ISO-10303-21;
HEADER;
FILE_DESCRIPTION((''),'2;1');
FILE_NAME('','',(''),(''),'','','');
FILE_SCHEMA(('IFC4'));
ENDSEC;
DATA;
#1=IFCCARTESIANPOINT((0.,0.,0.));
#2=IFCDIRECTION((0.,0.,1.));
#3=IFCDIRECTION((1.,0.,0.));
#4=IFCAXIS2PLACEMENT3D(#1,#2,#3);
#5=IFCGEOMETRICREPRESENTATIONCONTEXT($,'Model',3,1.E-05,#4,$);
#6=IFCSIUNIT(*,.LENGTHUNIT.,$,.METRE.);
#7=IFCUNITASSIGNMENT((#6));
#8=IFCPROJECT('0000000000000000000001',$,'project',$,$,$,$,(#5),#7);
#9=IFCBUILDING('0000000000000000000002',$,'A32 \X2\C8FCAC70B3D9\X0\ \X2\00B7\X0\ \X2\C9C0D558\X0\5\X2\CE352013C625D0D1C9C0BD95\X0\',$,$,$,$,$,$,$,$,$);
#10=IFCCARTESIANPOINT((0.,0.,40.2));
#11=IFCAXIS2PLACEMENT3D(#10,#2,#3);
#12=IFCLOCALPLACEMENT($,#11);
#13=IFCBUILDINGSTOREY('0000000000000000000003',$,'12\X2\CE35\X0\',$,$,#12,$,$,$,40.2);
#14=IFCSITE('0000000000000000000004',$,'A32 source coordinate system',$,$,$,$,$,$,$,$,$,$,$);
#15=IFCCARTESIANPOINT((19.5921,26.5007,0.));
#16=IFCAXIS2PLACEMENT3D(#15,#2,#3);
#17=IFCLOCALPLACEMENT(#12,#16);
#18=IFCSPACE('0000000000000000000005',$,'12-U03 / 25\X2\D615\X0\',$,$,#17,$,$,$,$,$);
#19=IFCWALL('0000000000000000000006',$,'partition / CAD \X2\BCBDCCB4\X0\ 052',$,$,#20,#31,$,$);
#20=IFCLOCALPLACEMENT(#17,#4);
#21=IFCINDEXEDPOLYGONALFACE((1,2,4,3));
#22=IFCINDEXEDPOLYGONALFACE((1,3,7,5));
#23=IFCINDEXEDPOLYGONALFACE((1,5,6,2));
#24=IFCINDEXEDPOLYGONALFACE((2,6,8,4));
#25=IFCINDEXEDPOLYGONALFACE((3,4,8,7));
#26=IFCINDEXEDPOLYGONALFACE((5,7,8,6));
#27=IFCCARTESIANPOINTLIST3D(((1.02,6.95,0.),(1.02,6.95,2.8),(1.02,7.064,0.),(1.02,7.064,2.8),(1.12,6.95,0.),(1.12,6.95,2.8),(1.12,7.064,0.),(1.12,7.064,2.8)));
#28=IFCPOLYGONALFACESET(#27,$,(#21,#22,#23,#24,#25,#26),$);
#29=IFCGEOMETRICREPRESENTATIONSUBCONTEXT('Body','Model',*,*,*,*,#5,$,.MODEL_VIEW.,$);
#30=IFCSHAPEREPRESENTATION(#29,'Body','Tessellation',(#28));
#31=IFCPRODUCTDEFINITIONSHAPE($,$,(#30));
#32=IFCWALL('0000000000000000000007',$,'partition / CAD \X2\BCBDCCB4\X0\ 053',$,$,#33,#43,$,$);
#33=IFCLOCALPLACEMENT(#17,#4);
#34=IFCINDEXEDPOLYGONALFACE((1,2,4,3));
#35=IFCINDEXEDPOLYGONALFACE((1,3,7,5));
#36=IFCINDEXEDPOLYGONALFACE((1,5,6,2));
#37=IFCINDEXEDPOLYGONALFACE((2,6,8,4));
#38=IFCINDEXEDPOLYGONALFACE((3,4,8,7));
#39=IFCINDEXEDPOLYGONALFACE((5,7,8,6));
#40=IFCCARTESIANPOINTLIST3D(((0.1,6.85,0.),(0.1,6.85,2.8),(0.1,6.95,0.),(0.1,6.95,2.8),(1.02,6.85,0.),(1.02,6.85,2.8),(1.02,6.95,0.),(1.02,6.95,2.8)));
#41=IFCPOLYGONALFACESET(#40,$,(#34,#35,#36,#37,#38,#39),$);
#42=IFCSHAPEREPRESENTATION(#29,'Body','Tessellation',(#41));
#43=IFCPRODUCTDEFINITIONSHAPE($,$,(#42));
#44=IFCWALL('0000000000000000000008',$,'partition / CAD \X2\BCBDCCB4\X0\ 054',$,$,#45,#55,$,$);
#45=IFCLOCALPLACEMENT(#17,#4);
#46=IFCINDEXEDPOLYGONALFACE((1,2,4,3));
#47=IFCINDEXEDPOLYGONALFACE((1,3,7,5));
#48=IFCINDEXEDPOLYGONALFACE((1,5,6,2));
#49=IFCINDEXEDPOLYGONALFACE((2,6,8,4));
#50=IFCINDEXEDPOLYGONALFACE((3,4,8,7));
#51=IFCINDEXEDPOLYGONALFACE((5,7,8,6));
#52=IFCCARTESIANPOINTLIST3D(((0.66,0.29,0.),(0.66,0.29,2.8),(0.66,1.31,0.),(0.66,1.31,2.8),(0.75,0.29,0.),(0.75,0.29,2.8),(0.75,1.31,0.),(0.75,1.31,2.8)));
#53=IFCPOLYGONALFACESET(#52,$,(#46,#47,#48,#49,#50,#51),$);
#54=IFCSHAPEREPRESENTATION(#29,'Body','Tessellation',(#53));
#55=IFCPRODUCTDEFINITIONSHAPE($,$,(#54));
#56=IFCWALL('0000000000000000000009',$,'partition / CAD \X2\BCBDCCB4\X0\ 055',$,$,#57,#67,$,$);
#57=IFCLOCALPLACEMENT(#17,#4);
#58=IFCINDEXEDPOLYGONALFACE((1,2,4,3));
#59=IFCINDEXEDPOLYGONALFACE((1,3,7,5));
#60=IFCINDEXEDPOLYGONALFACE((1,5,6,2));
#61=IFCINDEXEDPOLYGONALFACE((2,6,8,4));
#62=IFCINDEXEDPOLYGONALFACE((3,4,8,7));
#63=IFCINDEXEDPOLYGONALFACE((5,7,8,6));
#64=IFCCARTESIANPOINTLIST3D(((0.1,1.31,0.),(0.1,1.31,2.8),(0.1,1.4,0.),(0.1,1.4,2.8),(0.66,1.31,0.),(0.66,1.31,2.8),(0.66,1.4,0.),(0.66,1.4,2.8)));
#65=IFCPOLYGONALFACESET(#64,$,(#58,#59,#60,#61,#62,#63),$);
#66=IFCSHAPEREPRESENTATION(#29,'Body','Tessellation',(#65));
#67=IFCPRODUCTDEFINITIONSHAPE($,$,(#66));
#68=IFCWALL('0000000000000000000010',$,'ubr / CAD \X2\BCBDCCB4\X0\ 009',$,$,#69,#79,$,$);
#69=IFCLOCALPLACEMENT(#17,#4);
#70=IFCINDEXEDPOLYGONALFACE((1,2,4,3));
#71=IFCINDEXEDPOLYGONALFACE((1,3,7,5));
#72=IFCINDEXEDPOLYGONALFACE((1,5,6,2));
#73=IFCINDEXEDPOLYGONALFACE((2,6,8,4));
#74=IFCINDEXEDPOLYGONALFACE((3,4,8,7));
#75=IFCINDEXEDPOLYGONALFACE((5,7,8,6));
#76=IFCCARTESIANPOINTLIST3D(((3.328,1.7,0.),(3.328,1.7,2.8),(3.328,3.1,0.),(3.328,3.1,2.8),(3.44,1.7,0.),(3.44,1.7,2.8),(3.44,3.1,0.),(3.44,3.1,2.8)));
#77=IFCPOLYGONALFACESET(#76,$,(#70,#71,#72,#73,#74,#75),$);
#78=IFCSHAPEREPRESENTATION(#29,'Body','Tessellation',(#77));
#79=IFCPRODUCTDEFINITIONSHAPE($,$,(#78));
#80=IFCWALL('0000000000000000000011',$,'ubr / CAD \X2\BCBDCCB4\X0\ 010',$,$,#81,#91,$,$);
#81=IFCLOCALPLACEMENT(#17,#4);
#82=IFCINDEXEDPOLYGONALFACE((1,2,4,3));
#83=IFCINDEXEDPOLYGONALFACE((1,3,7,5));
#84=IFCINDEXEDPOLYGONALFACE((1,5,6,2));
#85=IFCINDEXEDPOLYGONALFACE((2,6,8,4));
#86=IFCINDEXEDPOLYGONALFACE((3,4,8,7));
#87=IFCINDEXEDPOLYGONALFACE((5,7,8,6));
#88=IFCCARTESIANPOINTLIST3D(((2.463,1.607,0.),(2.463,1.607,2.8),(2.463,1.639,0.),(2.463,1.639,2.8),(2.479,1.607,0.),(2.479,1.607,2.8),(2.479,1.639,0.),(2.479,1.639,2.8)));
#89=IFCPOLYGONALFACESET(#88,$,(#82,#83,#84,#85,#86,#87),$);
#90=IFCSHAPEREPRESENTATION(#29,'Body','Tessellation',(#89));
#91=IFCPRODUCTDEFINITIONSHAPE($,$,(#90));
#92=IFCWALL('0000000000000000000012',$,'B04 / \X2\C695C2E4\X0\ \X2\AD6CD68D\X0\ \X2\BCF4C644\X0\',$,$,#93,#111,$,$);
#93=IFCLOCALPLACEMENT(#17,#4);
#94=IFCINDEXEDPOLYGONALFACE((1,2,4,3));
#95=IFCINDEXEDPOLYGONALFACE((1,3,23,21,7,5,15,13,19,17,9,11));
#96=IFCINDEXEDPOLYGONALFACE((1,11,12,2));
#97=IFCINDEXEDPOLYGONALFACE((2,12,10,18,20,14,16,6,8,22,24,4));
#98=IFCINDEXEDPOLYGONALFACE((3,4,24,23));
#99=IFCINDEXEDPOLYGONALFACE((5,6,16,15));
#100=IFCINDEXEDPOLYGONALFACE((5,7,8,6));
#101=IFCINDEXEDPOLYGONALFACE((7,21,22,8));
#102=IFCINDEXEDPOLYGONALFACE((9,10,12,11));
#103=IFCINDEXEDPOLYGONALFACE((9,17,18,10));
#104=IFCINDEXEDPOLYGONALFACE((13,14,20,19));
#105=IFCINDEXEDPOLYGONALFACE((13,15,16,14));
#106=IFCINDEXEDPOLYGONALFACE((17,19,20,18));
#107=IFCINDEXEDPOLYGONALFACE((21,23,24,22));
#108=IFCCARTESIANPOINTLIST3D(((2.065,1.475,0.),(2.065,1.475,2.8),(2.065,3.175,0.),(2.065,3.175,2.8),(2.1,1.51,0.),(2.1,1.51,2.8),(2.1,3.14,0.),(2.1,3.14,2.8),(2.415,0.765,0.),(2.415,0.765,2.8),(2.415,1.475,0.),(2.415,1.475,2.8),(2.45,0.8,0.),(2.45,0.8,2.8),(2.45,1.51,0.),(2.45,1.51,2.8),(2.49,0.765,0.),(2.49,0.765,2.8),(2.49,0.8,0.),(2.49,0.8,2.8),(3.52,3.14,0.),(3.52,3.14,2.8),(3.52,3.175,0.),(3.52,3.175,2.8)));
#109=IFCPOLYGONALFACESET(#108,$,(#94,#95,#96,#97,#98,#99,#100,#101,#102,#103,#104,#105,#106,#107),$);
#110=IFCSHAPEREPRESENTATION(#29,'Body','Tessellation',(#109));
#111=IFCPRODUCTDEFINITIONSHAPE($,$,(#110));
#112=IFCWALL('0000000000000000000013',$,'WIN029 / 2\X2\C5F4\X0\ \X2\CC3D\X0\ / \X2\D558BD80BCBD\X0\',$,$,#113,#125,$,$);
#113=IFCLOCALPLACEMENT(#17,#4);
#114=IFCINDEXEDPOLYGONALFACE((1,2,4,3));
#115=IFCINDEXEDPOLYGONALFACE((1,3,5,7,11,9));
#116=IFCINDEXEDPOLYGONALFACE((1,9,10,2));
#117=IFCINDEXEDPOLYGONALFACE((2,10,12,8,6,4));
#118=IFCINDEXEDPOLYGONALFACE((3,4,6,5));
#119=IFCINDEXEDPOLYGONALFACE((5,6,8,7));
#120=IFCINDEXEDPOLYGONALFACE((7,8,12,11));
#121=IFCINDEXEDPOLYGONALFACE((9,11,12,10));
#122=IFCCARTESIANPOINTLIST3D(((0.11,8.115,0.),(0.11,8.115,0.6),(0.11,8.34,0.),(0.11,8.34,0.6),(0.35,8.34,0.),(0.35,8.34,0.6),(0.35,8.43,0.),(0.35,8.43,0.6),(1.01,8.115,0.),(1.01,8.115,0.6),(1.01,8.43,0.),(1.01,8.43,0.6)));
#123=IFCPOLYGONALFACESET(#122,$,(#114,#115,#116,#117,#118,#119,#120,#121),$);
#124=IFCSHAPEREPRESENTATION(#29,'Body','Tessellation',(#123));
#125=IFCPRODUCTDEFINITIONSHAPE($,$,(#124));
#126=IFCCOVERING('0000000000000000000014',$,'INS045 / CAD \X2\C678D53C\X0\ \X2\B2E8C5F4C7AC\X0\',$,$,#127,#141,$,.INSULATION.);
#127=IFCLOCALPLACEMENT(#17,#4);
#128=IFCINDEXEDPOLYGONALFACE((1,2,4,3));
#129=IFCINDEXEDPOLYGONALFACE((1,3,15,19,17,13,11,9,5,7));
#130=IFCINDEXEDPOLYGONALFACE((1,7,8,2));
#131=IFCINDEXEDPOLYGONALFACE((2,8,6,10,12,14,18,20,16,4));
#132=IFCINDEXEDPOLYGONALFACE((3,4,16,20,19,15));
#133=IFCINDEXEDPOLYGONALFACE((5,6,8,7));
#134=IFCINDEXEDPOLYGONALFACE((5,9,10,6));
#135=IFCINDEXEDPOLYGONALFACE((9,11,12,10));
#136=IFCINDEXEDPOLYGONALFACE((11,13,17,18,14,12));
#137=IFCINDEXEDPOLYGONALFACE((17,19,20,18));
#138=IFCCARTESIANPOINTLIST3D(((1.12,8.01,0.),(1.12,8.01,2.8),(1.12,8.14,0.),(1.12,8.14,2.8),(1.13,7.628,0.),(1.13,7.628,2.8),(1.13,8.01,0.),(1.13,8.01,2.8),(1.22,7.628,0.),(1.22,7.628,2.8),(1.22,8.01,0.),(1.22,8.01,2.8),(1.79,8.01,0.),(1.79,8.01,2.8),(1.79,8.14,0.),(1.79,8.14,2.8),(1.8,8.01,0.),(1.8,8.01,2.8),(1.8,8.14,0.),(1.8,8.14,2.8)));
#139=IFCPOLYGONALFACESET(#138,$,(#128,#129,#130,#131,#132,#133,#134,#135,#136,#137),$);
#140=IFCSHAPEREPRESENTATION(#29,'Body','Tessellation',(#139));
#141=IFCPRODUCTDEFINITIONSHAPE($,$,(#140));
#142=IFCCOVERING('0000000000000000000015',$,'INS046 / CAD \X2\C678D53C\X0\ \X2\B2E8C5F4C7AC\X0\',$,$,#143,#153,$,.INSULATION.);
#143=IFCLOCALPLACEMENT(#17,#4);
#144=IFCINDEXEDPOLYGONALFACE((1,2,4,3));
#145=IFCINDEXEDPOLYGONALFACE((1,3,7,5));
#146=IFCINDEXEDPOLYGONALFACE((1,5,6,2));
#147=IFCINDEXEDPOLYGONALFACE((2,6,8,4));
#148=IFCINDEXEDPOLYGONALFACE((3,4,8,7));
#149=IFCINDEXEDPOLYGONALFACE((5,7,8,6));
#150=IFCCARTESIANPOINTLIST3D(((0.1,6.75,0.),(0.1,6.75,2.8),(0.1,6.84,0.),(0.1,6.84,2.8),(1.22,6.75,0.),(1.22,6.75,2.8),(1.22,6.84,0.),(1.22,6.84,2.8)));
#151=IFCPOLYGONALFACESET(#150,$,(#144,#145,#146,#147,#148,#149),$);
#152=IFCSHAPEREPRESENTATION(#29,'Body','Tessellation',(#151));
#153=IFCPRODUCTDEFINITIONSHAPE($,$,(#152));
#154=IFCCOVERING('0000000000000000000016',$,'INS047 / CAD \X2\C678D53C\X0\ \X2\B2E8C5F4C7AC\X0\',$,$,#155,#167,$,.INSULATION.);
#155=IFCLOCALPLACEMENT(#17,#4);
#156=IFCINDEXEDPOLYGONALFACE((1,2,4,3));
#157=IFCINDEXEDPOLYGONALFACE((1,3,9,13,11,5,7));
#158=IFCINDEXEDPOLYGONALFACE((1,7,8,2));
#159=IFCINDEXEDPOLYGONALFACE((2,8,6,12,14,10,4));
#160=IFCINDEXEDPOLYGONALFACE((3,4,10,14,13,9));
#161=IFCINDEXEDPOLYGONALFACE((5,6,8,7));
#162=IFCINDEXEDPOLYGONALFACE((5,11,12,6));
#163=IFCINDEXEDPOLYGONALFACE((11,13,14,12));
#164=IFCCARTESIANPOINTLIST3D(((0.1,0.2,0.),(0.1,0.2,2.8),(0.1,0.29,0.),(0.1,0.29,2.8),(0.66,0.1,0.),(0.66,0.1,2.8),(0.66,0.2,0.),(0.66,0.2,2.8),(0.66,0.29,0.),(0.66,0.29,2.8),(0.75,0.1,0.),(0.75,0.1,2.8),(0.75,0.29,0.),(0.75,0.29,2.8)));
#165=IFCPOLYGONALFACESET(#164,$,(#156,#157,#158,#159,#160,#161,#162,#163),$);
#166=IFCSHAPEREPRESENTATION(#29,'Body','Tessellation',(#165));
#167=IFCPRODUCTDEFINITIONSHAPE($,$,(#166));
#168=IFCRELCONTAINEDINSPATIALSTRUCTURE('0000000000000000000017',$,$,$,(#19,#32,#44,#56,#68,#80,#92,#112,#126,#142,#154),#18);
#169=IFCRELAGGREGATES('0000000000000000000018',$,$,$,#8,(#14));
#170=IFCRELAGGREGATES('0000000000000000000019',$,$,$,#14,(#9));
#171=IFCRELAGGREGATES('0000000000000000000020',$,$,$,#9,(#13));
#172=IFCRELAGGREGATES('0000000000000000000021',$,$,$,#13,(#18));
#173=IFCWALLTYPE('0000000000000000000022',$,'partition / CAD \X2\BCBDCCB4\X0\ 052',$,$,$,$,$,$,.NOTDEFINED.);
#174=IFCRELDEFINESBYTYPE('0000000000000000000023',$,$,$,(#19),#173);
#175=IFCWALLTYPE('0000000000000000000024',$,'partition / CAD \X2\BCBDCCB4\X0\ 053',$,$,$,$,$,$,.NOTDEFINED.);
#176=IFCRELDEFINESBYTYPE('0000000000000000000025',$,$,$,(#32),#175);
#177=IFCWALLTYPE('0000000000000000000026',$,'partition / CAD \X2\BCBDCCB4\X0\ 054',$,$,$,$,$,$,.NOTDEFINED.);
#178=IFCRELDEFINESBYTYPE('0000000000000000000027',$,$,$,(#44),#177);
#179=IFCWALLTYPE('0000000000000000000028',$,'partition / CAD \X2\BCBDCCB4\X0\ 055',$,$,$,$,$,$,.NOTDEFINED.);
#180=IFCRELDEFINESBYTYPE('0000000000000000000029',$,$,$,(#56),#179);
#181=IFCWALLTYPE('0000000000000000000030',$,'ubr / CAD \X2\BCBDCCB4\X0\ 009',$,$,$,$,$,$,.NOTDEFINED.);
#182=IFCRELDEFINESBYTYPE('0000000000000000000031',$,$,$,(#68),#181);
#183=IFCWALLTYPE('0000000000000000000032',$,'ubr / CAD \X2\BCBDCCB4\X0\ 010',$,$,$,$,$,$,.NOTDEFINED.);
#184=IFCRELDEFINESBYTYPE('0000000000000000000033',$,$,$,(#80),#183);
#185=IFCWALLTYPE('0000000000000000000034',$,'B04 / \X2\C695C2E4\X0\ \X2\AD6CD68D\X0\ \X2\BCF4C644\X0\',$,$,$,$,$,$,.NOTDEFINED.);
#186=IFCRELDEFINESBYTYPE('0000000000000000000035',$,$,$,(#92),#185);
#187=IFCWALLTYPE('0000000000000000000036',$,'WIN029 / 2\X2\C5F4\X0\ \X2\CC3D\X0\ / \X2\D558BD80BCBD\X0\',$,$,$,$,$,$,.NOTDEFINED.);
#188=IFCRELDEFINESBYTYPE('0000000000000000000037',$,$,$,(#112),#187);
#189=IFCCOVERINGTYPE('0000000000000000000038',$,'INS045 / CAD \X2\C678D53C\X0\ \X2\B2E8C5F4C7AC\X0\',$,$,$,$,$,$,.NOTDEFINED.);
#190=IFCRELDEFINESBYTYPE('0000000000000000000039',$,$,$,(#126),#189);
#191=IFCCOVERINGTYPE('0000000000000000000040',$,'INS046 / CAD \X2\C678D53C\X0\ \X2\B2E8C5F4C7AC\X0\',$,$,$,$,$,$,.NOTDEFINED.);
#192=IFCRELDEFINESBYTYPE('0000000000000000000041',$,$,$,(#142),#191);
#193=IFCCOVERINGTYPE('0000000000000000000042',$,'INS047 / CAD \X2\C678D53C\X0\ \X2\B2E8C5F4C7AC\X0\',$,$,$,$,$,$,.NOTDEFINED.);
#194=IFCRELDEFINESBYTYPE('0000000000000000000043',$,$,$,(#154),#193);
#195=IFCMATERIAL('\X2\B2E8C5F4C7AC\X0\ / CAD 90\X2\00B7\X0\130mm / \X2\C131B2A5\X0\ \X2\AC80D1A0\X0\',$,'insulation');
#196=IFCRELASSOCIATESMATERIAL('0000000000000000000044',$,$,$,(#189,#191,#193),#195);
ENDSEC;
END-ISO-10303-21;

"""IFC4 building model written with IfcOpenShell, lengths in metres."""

from ifc_helpers import new_model, si_unit, frame, origin, origin_with_axes, place, context, subcontext, project, spatial, polyline, outline, extrude, source, transform, mapped, material, type_object, type_shapes, element, save


model = new_model("IFC4")

# Units and contexts
model_context = context("Model", 3, precision=1e-05, world=origin_with_axes())
body_context = subcontext(model_context, "Body", "Model", "MODEL_VIEW")
ifc_project = project(units=[si_unit("LENGTHUNIT", "METRE")], contexts=[model_context])

# Site, building, storey, space
storey_placement = place(None, frame((0.0, 0.0, 40.2), z_axis=(0.0, 0.0, 1.0), x_axis=(1.0, 0.0, 0.0)))
space_placement = place(storey_placement, frame((19.5921, 26.5007, 0.0), z_axis=(0.0, 0.0, 1.0), x_axis=(1.0, 0.0, 0.0)))
site = spatial("IfcSite", under=ifc_project, Name="A32 source coordinate system")
building = spatial("IfcBuilding", under=site, Name="A32 주거동 · 지하5층–옥탑지붕")
storey = spatial("IfcBuildingStorey", under=building, at=storey_placement, Name="12층", Elevation=40.2)
space = spatial("IfcSpace", under=storey, at=space_placement, Name="12-U03 / 25형")

# Walls
wall_type_1 = type_object("IfcWallType", Name="partition / CAD 벽체 052", PredefinedType="NOTDEFINED")
shared_shape_1 = source(origin(), body_context, "Body", "SweptSolid", [
    extrude(outline(polyline([(1.12, 6.95), (1.02, 6.95), (1.02, 7.064), (1.12, 7.064), (1.12, 6.95)])), origin(), (0.0, 0.0, 1.0), 2.8),
])
type_shapes(wall_type_1, [shared_shape_1])
wall_1_placement = place(space_placement, origin_with_axes())
element("IfcWall", 1, at=wall_1_placement, inside=space, type_object=wall_type_1, Name="partition / CAD 벽체 052", context=body_context, shape_type="MappedRepresentation", body=[
    mapped(shared_shape_1, transform((0.0, 0.0, 0.0), scale=1.0)),
])
wall_type_2 = type_object("IfcWallType", Name="partition / CAD 벽체 053", PredefinedType="NOTDEFINED")
shared_shape_2 = source(origin(), body_context, "Body", "SweptSolid", [
    extrude(outline(polyline([(1.02, 6.95), (1.02, 6.85), (0.1, 6.85), (0.1, 6.95), (1.02, 6.95)])), origin(), (0.0, 0.0, 1.0), 2.8),
])
type_shapes(wall_type_2, [shared_shape_2])
wall_2_placement = place(space_placement, origin_with_axes())
element("IfcWall", 2, at=wall_2_placement, inside=space, type_object=wall_type_2, Name="partition / CAD 벽체 053", context=body_context, shape_type="MappedRepresentation", body=[
    mapped(shared_shape_2, transform((0.0, 0.0, 0.0), scale=1.0)),
])
wall_type_3 = type_object("IfcWallType", Name="partition / CAD 벽체 054", PredefinedType="NOTDEFINED")
shared_shape_3 = source(origin(), body_context, "Body", "SweptSolid", [
    extrude(outline(polyline([(0.75, 0.29), (0.66, 0.29), (0.66, 1.31), (0.75, 1.31), (0.75, 0.29)])), origin(), (0.0, 0.0, 1.0), 2.8),
])
type_shapes(wall_type_3, [shared_shape_3])
wall_3_placement = place(space_placement, origin_with_axes())
element("IfcWall", 3, at=wall_3_placement, inside=space, type_object=wall_type_3, Name="partition / CAD 벽체 054", context=body_context, shape_type="MappedRepresentation", body=[
    mapped(shared_shape_3, transform((0.0, 0.0, 0.0), scale=1.0)),
])
wall_type_4 = type_object("IfcWallType", Name="partition / CAD 벽체 055", PredefinedType="NOTDEFINED")
shared_shape_4 = source(origin(), body_context, "Body", "SweptSolid", [
    extrude(outline(polyline([(0.66, 1.4), (0.66, 1.31), (0.1, 1.31), (0.1, 1.4), (0.66, 1.4)])), origin(), (0.0, 0.0, 1.0), 2.8),
])
type_shapes(wall_type_4, [shared_shape_4])
wall_4_placement = place(space_placement, origin_with_axes())
element("IfcWall", 4, at=wall_4_placement, inside=space, type_object=wall_type_4, Name="partition / CAD 벽체 055", context=body_context, shape_type="MappedRepresentation", body=[
    mapped(shared_shape_4, transform((0.0, 0.0, 0.0), scale=1.0)),
])
wall_type_5 = type_object("IfcWallType", Name="ubr / CAD 벽체 009", PredefinedType="NOTDEFINED")
shared_shape_5 = source(origin(), body_context, "Body", "SweptSolid", [
    extrude(outline(polyline([(3.328, 3.1), (3.44, 3.1), (3.44, 1.7), (3.328, 1.7), (3.328, 3.1)])), origin(), (0.0, 0.0, 1.0), 2.8),
])
type_shapes(wall_type_5, [shared_shape_5])
wall_5_placement = place(space_placement, origin_with_axes())
element("IfcWall", 5, at=wall_5_placement, inside=space, type_object=wall_type_5, Name="ubr / CAD 벽체 009", context=body_context, shape_type="MappedRepresentation", body=[
    mapped(shared_shape_5, transform((0.0, 0.0, 0.0), scale=1.0)),
])
wall_type_6 = type_object("IfcWallType", Name="ubr / CAD 벽체 010", PredefinedType="NOTDEFINED")
shared_shape_6 = source(origin(), body_context, "Body", "SweptSolid", [
    extrude(outline(polyline([(2.463, 1.607), (2.463, 1.639), (2.479, 1.639), (2.479, 1.607), (2.463, 1.607)])), origin(), (0.0, 0.0, 1.0), 2.8),
])
type_shapes(wall_type_6, [shared_shape_6])
wall_6_placement = place(space_placement, origin_with_axes())
element("IfcWall", 6, at=wall_6_placement, inside=space, type_object=wall_type_6, Name="ubr / CAD 벽체 010", context=body_context, shape_type="MappedRepresentation", body=[
    mapped(shared_shape_6, transform((0.0, 0.0, 0.0), scale=1.0)),
])
wall_type_7 = type_object("IfcWallType", Name="B04 / 욕실 구획 보완", PredefinedType="NOTDEFINED")
shared_shape_7 = source(origin(), body_context, "Body", "SweptSolid", [
    extrude(outline(polyline([(3.52, 3.175), (3.52, 3.14), (2.1, 3.14), (2.1, 1.51), (2.45, 1.51), (2.45, 0.8), (2.49, 0.8), (2.49, 0.765), (2.415, 0.765), (2.415, 1.475), (2.065, 1.475), (2.065, 3.175), (3.52, 3.175)])), origin(), (0.0, 0.0, 1.0), 2.8),
])
type_shapes(wall_type_7, [shared_shape_7])
wall_7_placement = place(space_placement, origin_with_axes())
element("IfcWall", 7, at=wall_7_placement, inside=space, type_object=wall_type_7, Name="B04 / 욕실 구획 보완", context=body_context, shape_type="MappedRepresentation", body=[
    mapped(shared_shape_7, transform((0.0, 0.0, 0.0), scale=1.0)),
])
wall_type_8 = type_object("IfcWallType", Name="WIN029 / 2열 창 / 하부벽", PredefinedType="NOTDEFINED")
shared_shape_8 = source(origin(), body_context, "Body", "SweptSolid", [
    extrude(outline(polyline([(1.01, 8.115), (0.11, 8.115), (0.11, 8.34), (0.35, 8.34), (0.35, 8.43), (1.01, 8.43), (1.01, 8.115)])), origin(), (0.0, 0.0, 1.0), 0.6),
])
type_shapes(wall_type_8, [shared_shape_8])
wall_8_placement = place(space_placement, origin_with_axes())
element("IfcWall", 8, at=wall_8_placement, inside=space, type_object=wall_type_8, Name="WIN029 / 2열 창 / 하부벽", context=body_context, shape_type="MappedRepresentation", body=[
    mapped(shared_shape_8, transform((0.0, 0.0, 0.0), scale=1.0)),
])

# Coverings
ifc_material = material(Name="단열재 / CAD 90·130mm / 성능 검토", Category="insulation")
covering_type_1 = type_object("IfcCoveringType", Name="INS045 / CAD 외피 단열재", PredefinedType="NOTDEFINED", material=ifc_material)
shared_shape_9 = source(origin(), body_context, "Body", "SweptSolid", [
    extrude(outline(polyline([(1.22, 8.01), (1.22, 7.628), (1.13, 7.628), (1.13, 8.01), (1.12, 8.01), (1.12, 8.14), (1.79, 8.14), (1.8, 8.14), (1.8, 8.01), (1.79, 8.01), (1.22, 8.01)])), origin(), (0.0, 0.0, 1.0), 2.8),
])
type_shapes(covering_type_1, [shared_shape_9])
covering_1_placement = place(space_placement, origin_with_axes())
element("IfcCovering", 9, at=covering_1_placement, inside=space, type_object=covering_type_1, Name="INS045 / CAD 외피 단열재", PredefinedType="INSULATION", context=body_context, shape_type="MappedRepresentation", body=[
    mapped(shared_shape_9, transform((0.0, 0.0, 0.0), scale=1.0)),
])
covering_type_2 = type_object("IfcCoveringType", Name="INS046 / CAD 외피 단열재", PredefinedType="NOTDEFINED", material=ifc_material)
shared_shape_10 = source(origin(), body_context, "Body", "SweptSolid", [
    extrude(outline(polyline([(0.1, 6.84), (1.22, 6.84), (1.22, 6.75), (0.1, 6.75), (0.1, 6.84)])), origin(), (0.0, 0.0, 1.0), 2.8),
])
type_shapes(covering_type_2, [shared_shape_10])
covering_2_placement = place(space_placement, origin_with_axes())
element("IfcCovering", 10, at=covering_2_placement, inside=space, type_object=covering_type_2, Name="INS046 / CAD 외피 단열재", PredefinedType="INSULATION", context=body_context, shape_type="MappedRepresentation", body=[
    mapped(shared_shape_10, transform((0.0, 0.0, 0.0), scale=1.0)),
])
covering_type_3 = type_object("IfcCoveringType", Name="INS047 / CAD 외피 단열재", PredefinedType="NOTDEFINED", material=ifc_material)
shared_shape_11 = source(origin(), body_context, "Body", "SweptSolid", [
    extrude(outline(polyline([(0.1, 0.2), (0.1, 0.29), (0.66, 0.29), (0.75, 0.29), (0.75, 0.1), (0.66, 0.1), (0.66, 0.2), (0.1, 0.2)])), origin(), (0.0, 0.0, 1.0), 2.8),
])
type_shapes(covering_type_3, [shared_shape_11])
covering_3_placement = place(space_placement, origin_with_axes())
element("IfcCovering", 11, at=covering_3_placement, inside=space, type_object=covering_type_3, Name="INS047 / CAD 외피 단열재", PredefinedType="INSULATION", context=body_context, shape_type="MappedRepresentation", body=[
    mapped(shared_shape_11, transform((0.0, 0.0, 0.0), scale=1.0)),
])

save(model, "model.ifc")
